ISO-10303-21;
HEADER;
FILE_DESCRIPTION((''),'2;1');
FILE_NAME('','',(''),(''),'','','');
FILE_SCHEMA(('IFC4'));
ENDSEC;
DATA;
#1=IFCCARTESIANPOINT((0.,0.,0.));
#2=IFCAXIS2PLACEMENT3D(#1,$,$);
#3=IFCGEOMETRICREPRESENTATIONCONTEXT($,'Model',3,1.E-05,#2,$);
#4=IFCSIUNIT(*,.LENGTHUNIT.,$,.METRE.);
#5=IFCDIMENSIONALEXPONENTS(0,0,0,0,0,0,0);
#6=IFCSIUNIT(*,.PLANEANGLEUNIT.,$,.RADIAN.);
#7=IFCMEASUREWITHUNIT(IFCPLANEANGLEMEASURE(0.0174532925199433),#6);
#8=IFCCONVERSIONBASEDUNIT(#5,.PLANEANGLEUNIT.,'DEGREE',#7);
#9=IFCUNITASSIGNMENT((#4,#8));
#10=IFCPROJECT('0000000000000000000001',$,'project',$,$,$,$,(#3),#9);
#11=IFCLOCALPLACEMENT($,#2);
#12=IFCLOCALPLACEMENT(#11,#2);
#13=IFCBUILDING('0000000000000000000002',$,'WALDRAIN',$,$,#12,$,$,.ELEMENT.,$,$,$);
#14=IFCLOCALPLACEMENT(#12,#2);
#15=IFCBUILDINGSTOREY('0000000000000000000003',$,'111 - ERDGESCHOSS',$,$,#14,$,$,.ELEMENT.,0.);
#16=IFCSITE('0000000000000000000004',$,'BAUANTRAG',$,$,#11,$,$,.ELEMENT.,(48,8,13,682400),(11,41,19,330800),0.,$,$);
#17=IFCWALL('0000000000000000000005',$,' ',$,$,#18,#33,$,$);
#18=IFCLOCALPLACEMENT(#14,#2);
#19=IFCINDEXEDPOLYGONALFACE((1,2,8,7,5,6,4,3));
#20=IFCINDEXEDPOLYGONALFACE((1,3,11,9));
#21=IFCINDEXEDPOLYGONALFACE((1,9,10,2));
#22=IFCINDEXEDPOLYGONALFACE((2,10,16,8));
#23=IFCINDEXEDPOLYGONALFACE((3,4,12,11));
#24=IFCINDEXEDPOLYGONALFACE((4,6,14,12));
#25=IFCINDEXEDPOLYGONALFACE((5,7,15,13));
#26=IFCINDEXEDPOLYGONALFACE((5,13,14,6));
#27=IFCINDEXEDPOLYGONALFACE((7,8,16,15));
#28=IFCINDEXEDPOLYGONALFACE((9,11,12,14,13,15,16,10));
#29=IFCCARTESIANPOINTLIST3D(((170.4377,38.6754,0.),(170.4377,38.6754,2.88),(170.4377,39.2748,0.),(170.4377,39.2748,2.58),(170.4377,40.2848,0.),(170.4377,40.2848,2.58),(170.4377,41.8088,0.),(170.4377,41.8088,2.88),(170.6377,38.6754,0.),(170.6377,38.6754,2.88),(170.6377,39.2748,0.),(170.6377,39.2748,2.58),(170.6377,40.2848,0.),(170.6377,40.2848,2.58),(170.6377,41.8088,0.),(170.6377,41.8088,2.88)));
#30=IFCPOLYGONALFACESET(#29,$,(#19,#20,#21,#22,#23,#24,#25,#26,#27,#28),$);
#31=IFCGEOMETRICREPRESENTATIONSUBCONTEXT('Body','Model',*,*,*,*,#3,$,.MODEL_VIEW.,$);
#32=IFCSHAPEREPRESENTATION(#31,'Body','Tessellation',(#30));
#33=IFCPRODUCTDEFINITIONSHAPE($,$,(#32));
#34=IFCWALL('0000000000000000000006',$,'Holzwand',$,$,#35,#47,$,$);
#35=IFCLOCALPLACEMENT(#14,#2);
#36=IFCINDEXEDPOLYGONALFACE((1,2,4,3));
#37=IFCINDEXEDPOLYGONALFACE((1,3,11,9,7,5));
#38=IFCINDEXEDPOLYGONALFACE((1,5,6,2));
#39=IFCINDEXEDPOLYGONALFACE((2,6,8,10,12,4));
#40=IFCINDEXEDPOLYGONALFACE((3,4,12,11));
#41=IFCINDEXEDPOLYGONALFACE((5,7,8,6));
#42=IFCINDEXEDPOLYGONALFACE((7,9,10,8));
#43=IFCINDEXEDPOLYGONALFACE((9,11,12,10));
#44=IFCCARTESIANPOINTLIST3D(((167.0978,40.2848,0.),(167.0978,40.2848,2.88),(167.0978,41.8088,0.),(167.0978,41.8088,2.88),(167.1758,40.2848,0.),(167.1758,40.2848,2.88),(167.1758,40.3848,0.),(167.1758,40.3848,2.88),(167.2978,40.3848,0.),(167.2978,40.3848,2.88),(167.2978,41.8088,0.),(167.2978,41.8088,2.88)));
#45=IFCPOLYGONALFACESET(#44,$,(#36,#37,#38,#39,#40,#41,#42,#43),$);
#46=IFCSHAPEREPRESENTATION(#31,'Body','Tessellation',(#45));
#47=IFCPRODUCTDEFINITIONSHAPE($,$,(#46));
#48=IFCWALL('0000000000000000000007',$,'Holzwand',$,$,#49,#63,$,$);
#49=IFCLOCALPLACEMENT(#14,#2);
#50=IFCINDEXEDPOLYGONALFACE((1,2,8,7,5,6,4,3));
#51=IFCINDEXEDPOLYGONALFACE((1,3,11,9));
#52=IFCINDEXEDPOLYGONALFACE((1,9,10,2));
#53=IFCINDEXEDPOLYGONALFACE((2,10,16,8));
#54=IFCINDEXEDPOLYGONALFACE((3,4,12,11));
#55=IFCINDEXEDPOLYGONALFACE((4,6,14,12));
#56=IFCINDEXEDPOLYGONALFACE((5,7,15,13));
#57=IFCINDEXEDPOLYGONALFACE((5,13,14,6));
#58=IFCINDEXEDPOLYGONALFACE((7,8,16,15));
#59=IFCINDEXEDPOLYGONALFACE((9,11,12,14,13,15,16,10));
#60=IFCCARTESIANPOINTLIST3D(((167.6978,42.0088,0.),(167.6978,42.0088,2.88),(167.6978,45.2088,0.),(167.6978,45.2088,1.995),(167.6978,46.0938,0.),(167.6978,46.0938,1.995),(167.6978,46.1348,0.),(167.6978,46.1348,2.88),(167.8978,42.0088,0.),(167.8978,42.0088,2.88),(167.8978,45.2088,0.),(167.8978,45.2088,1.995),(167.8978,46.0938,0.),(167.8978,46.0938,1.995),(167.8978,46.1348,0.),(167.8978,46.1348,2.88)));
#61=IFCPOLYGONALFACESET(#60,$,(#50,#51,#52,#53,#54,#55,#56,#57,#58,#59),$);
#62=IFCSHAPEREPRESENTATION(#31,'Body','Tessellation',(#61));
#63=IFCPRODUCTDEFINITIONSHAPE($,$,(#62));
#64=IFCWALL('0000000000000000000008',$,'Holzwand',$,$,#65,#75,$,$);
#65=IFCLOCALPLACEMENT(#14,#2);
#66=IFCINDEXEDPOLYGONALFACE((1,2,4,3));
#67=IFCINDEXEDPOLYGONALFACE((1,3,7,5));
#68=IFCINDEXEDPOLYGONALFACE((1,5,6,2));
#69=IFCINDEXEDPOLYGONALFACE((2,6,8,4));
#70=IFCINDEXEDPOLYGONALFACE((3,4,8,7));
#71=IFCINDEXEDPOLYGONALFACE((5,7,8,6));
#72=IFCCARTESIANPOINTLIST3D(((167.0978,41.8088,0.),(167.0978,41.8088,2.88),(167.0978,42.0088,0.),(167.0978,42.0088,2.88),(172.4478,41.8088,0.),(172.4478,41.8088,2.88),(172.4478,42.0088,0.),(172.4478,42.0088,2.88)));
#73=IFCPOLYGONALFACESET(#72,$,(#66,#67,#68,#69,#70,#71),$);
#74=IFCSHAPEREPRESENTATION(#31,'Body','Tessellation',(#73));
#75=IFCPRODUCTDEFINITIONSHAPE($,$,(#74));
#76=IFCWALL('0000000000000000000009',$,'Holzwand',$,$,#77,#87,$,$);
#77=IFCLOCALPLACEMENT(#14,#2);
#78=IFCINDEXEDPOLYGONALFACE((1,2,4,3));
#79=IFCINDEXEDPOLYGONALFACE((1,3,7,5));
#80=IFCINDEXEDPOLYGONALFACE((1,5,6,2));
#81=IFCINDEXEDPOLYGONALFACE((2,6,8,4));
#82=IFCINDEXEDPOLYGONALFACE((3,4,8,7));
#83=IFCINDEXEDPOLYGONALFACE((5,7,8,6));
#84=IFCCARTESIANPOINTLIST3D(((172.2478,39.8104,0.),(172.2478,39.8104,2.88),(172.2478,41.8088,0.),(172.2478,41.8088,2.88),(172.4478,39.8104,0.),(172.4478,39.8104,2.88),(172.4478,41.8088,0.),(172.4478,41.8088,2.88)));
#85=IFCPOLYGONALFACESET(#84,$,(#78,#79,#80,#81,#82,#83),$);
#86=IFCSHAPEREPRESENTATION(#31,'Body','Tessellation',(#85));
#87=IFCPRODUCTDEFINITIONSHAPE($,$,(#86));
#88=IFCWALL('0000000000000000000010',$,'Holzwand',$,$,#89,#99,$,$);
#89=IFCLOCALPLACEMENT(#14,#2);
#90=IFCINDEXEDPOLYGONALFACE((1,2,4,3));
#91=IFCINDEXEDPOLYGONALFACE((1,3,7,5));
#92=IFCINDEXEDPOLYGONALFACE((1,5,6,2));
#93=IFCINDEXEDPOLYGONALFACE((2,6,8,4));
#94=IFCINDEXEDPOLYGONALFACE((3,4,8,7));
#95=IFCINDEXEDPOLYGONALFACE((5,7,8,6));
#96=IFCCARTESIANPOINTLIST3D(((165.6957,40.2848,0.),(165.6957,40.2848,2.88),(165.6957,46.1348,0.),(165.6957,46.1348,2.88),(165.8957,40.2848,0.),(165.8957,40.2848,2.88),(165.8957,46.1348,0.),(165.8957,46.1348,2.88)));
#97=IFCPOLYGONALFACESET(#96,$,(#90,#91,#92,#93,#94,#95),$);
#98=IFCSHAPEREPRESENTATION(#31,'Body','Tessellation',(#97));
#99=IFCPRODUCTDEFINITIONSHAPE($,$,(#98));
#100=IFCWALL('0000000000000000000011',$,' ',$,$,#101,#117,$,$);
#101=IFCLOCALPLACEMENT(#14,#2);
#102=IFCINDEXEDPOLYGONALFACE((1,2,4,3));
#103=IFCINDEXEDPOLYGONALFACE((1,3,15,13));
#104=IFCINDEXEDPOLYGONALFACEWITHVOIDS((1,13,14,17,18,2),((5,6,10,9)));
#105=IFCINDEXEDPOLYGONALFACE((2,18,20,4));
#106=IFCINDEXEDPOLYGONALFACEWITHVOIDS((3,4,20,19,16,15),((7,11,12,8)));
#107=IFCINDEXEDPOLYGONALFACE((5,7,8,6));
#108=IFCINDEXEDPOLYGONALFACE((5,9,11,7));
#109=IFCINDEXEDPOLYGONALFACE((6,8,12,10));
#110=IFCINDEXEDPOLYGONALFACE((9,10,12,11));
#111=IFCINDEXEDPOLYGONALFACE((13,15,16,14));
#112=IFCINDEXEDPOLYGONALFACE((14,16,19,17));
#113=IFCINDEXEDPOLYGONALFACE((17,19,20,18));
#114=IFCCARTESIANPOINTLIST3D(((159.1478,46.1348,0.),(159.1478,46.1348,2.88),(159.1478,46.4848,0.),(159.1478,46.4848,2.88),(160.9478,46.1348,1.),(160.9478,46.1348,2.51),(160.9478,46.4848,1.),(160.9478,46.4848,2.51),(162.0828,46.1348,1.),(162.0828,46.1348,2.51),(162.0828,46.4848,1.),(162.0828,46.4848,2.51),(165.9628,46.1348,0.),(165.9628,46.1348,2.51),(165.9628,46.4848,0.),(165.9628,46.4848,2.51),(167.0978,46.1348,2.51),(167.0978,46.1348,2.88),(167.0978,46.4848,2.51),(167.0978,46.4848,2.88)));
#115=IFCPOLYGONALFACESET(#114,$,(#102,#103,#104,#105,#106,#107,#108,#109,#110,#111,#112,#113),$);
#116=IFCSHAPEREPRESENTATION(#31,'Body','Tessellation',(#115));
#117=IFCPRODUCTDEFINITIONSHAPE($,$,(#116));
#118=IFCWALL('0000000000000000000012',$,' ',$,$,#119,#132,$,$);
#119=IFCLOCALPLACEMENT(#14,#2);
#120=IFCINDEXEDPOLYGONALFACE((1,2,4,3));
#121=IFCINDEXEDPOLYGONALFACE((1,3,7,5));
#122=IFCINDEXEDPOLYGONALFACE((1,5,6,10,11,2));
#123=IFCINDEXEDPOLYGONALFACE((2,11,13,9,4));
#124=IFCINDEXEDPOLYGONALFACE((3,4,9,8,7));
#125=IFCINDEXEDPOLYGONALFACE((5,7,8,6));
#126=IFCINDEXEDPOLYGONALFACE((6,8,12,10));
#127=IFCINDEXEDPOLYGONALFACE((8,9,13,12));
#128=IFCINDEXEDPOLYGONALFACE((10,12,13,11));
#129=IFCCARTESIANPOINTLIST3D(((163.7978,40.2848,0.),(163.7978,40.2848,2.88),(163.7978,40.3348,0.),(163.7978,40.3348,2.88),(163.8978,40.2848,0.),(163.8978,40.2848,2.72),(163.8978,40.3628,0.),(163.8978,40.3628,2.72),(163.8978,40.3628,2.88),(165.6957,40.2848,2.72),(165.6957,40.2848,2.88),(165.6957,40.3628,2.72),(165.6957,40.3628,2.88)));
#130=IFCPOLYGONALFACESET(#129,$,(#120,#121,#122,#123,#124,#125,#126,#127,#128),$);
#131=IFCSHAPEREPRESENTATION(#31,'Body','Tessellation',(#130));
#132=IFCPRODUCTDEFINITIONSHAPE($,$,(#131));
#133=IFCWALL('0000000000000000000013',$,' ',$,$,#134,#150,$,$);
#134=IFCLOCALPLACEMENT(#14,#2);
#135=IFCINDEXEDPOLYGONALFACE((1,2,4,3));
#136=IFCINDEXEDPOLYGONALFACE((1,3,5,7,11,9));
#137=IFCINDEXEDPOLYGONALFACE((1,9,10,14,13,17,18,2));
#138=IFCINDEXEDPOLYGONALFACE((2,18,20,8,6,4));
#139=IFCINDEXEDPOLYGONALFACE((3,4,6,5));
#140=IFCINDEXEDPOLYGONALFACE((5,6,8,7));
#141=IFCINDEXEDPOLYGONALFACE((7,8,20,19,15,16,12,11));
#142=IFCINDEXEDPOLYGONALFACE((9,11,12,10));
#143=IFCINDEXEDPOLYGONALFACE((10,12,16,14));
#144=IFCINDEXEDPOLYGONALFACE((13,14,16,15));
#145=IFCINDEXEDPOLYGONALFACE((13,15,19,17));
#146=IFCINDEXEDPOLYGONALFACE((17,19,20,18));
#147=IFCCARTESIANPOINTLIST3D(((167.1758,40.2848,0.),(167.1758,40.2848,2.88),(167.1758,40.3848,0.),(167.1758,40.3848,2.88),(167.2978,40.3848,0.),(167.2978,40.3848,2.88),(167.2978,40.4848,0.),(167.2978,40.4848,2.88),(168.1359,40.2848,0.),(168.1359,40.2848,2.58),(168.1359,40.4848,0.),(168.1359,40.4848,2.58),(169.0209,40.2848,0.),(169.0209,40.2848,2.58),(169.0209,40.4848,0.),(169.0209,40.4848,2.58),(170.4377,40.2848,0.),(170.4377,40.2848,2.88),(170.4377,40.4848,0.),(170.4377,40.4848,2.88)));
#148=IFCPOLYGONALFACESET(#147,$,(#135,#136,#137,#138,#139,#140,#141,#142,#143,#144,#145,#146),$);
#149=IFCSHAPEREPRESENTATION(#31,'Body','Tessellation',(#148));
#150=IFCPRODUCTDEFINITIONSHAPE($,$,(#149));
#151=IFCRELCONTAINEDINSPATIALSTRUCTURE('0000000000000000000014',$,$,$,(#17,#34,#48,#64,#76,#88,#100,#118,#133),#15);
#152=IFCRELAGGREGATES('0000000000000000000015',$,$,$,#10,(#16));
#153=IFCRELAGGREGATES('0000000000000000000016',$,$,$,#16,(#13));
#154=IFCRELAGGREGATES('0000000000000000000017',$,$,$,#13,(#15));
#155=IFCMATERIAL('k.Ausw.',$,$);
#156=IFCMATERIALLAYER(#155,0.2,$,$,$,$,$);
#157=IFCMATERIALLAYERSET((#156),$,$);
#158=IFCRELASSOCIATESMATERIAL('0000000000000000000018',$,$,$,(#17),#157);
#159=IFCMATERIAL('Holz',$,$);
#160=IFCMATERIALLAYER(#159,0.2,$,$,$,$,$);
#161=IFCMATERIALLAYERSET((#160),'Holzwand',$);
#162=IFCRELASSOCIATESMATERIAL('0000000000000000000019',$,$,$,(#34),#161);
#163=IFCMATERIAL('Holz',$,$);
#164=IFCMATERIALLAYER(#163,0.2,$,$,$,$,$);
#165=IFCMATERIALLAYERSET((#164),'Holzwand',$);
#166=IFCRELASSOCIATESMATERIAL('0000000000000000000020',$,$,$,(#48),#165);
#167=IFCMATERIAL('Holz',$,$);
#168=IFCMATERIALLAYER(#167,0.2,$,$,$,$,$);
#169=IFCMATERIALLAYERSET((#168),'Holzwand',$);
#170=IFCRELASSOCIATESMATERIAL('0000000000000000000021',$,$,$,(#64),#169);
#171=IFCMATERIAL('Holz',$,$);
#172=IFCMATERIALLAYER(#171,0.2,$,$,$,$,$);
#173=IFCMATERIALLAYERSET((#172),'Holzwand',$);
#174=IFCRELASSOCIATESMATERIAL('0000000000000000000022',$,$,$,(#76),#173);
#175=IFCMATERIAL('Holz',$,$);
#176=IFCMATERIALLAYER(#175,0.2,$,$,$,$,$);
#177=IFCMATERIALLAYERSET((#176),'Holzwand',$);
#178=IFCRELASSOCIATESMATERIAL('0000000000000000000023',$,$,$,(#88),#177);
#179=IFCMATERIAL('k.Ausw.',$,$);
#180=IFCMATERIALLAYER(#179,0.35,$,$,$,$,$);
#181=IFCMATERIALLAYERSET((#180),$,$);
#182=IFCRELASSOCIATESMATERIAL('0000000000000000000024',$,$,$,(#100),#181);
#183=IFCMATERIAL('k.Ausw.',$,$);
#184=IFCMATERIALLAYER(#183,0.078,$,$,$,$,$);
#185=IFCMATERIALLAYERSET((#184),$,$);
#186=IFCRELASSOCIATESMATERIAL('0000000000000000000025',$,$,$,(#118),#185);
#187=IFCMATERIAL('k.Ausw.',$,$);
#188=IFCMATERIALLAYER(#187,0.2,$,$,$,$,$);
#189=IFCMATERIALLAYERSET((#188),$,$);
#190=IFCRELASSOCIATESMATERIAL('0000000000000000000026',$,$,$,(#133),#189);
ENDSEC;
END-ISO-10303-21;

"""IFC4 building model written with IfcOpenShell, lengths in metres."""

from ifc_helpers import new_model, entity, si_unit, converted_unit, frame, frame_2d, origin, origin_with_axes, place, context, subcontext, project, spatial, polyline, rectangle, outline, extrude, material, layer, layer_set, layer_usage, element, save


model = new_model("IFC4")

# Units and contexts
model_context = context("Model", 3, precision=1e-05, world=origin())
body_context = subcontext(model_context, "Body", "Model", "MODEL_VIEW")
ifc_project = project(units=[si_unit("LENGTHUNIT", "METRE"), converted_unit("PLANEANGLEUNIT", "DEGREE", entity("IfcPlaneAngleMeasure", 0.0174532925199433), si_unit("PLANEANGLEUNIT", "RADIAN"), dimensions=[0, 0, 0, 0, 0, 0, 0])], contexts=[model_context])

# Site, building, storey
site_placement = place(None, origin())
site = spatial("IfcSite", under=ifc_project, at=site_placement, Name="BAUANTRAG", CompositionType="ELEMENT", RefLatitude=(48, 8, 13, 682400), RefLongitude=(11, 41, 19, 330800), RefElevation=0.0)
building_placement = place(site_placement, origin())
building = spatial("IfcBuilding", under=site, at=building_placement, Name="WALDRAIN", CompositionType="ELEMENT")
storey_placement = place(building_placement, origin())
storey = spatial("IfcBuildingStorey", under=building, at=storey_placement, Name="111 - ERDGESCHOSS", CompositionType="ELEMENT", Elevation=0.0)

# Wall, opening
ifc_material_1 = material(Name="k.Ausw.")
ifc_layer_1 = layer(ifc_material_1, 0.2)
ifc_layer_set_1 = layer_set([ifc_layer_1])
ifc_layer_usage_1 = layer_usage(ifc_layer_set_1, "AXIS2", "POSITIVE", 0.0)
wall_1_placement = place(storey_placement, frame((170.4377, 41.8088, 0.0), z_axis=(0.0, 0.0, 1.0), x_axis=(0.0, -1.0, 0.0)))
wall_1 = element("IfcWall", 1, at=wall_1_placement, inside=storey, material=ifc_layer_usage_1, Name=" ", context=body_context, shape_type="SweptSolid", body=[
    extrude(rectangle(XDim=3.1334, YDim=0.2, at=frame_2d((1.5667, 0.1), x_axis=(1.0, 0.0))), origin_with_axes(), (0.0, 0.0, 1.0), 2.88),
])
opening_1_placement = place(wall_1_placement, frame((2.534, 0.2, -0.14), z_axis=(0.0, -1.0, 0.0), x_axis=(0.0, 0.0, 1.0)))
element("IfcOpeningElement", 2, at=opening_1_placement, cuts=wall_1, ObjectType="Opening", context=body_context, shape_type="SweptSolid", body=[
    extrude(outline(polyline([(0.0, 1.01), (2.72, 1.01), (2.72, 0.0), (0.0, 0.0), (0.0, 1.01)])), origin_with_axes(), (0.0, 0.0, 1.0), 0.2),
])

# Wall
ifc_material_2 = material(Name="Holz")
ifc_layer_2 = layer(ifc_material_2, 0.2)
ifc_layer_set_2 = layer_set([ifc_layer_2], Name="Holzwand")
ifc_layer_usage_2 = layer_usage(ifc_layer_set_2, "AXIS2", "POSITIVE", 0.0)
wall_2_placement = place(storey_placement, frame((167.0978, 41.8088, 0.0), z_axis=(0.0, 0.0, 1.0), x_axis=(0.0, -1.0, 0.0)))
element("IfcWall", 3, at=wall_2_placement, inside=storey, material=ifc_layer_usage_2, Name="Holzwand", context=body_context, shape_type="SweptSolid", body=[
    extrude(outline(polyline([(-1.524, 0.0), (0.0, 0.0), (0.0, 0.078), (-0.1, 0.078), (-0.1, 0.2), (-1.524, 0.2), (-1.524, 0.0)])), frame((1.524, 0.0, 0.0), z_axis=(0.0, 0.0, 1.0), x_axis=(1.0, 0.0, 0.0)), (0.0, 0.0, 1.0), 2.88),
])

# Wall, opening
ifc_material_3 = material(Name="Holz")
ifc_layer_3 = layer(ifc_material_3, 0.2)
ifc_layer_set_3 = layer_set([ifc_layer_3], Name="Holzwand")
ifc_layer_usage_3 = layer_usage(ifc_layer_set_3, "AXIS2", "POSITIVE", 0.0)
wall_3_placement = place(storey_placement, frame((167.6978, 46.1348, 0.0), z_axis=(0.0, 0.0, 1.0), x_axis=(0.0, -1.0, 0.0)))
wall_3 = element("IfcWall", 4, at=wall_3_placement, inside=storey, material=ifc_layer_usage_3, Name="Holzwand", context=body_context, shape_type="SweptSolid", body=[
    extrude(rectangle(XDim=4.126, YDim=0.2, at=frame_2d((2.063, 0.1), x_axis=(1.0, 0.0))), origin_with_axes(), (0.0, 0.0, 1.0), 2.88),
])
opening_2_placement = place(wall_3_placement, frame((0.926, 0.2, -0.14), z_axis=(0.0, -1.0, 0.0), x_axis=(0.0, 0.0, 1.0)))
element("IfcOpeningElement", 5, at=opening_2_placement, cuts=wall_3, ObjectType="Opening", context=body_context, shape_type="SweptSolid", body=[
    extrude(outline(polyline([(0.0, 0.885), (2.135, 0.885), (2.135, 0.0), (0.0, 0.0), (0.0, 0.885)])), origin_with_axes(), (0.0, 0.0, 1.0), 0.2),
])

# Walls
ifc_material_4 = material(Name="Holz")
ifc_layer_4 = layer(ifc_material_4, 0.2)
ifc_layer_set_4 = layer_set([ifc_layer_4], Name="Holzwand")
ifc_layer_usage_4 = layer_usage(ifc_layer_set_4, "AXIS2", "POSITIVE", 0.0)
wall_4_placement = place(storey_placement, frame((172.4478, 42.0088, 0.0), z_axis=(0.0, 0.0, 1.0), x_axis=(-1.0, 0.0, 0.0)))
element("IfcWall", 6, at=wall_4_placement, inside=storey, material=ifc_layer_usage_4, Name="Holzwand", context=body_context, shape_type="SweptSolid", body=[
    extrude(rectangle(XDim=5.35, YDim=0.2, at=frame_2d((2.675, 0.1), x_axis=(1.0, 0.0))), origin_with_axes(), (0.0, 0.0, 1.0), 2.88),
])
ifc_material_5 = material(Name="Holz")
ifc_layer_5 = layer(ifc_material_5, 0.2)
ifc_layer_set_5 = layer_set([ifc_layer_5], Name="Holzwand")
ifc_layer_usage_5 = layer_usage(ifc_layer_set_5, "AXIS2", "POSITIVE", 0.0)
wall_5_placement = place(storey_placement, frame((172.4478, 39.8104, 0.0), z_axis=(0.0, 0.0, 1.0), x_axis=(0.0, 1.0, 0.0)))
element("IfcWall", 7, at=wall_5_placement, inside=storey, material=ifc_layer_usage_5, Name="Holzwand", context=body_context, shape_type="SweptSolid", body=[
    extrude(rectangle(XDim=1.9984, YDim=0.2, at=frame_2d((0.9992, 0.1), x_axis=(1.0, 0.0))), origin_with_axes(), (0.0, 0.0, 1.0), 2.88),
])
ifc_material_6 = material(Name="Holz")
ifc_layer_6 = layer(ifc_material_6, 0.2)
ifc_layer_set_6 = layer_set([ifc_layer_6], Name="Holzwand")
ifc_layer_usage_6 = layer_usage(ifc_layer_set_6, "AXIS2", "POSITIVE", 0.0)
wall_6_placement = place(storey_placement, frame((165.6957, 46.1348, 0.0), z_axis=(0.0, 0.0, 1.0), x_axis=(0.0, -1.0, 0.0)))
element("IfcWall", 8, at=wall_6_placement, inside=storey, material=ifc_layer_usage_6, Name="Holzwand", context=body_context, shape_type="SweptSolid", body=[
    extrude(rectangle(XDim=5.85, YDim=0.2, at=frame_2d((2.925, 0.1), x_axis=(1.0, 0.0))), origin_with_axes(), (0.0, 0.0, 1.0), 2.88),
])

# Wall, openings
ifc_material_7 = material(Name="k.Ausw.")
ifc_layer_7 = layer(ifc_material_7, 0.35)
ifc_layer_set_7 = layer_set([ifc_layer_7])
ifc_layer_usage_7 = layer_usage(ifc_layer_set_7, "AXIS2", "POSITIVE", 0.0)
wall_7_placement = place(storey_placement, frame((167.0978, 46.4848, 0.0), z_axis=(0.0, 0.0, 1.0), x_axis=(-1.0, 0.0, 0.0)))
wall_7 = element("IfcWall", 9, at=wall_7_placement, inside=storey, material=ifc_layer_usage_7, Name=" ", context=body_context, shape_type="SweptSolid", body=[
    extrude(rectangle(XDim=7.95, YDim=0.35, at=frame_2d((3.975, 0.175), x_axis=(1.0, 0.0))), origin_with_axes(), (0.0, 0.0, 1.0), 2.88),
])
opening_3_placement = place(wall_7_placement, frame((6.15, 0.35, 1.0), z_axis=(0.0, -1.0, 0.0), x_axis=(0.0, 0.0, 1.0)))
element("IfcOpeningElement", 10, at=opening_3_placement, cuts=wall_7, ObjectType="Opening", context=body_context, shape_type="SweptSolid", body=[
    extrude(outline(polyline([(0.0, 1.135), (1.51, 1.135), (1.51, 0.0), (0.0, 0.0), (0.0, 1.135)])), origin_with_axes(), (0.0, 0.0, 1.0), 0.35),
])
opening_4_placement = place(wall_7_placement, frame((0.0, 0.0, -0.15), z_axis=(0.0, 1.0, 0.0), x_axis=(0.0, 0.0, 1.0)))
element("IfcOpeningElement", 11, at=opening_4_placement, cuts=wall_7, ObjectType="Opening", context=body_context, shape_type="SweptSolid", body=[
    extrude(outline(polyline([(0.0, 1.135), (2.66, 1.135), (2.66, 0.0), (0.0, 0.0), (0.0, 1.135)])), origin_with_axes(), (0.0, 0.0, 1.0), 0.35),
])

# Walls, openings
ifc_material_8 = material(Name="k.Ausw.")
ifc_layer_8 = layer(ifc_material_8, 0.078)
ifc_layer_set_8 = layer_set([ifc_layer_8])
ifc_layer_usage_8 = layer_usage(ifc_layer_set_8, "AXIS2", "POSITIVE", 0.0)
wall_8_placement = place(storey_placement, frame((165.6957, 40.3628, 0.0), z_axis=(0.0, 0.0, 1.0), x_axis=(-1.0, 0.0, 0.0)))
wall_8 = element("IfcWall", 12, at=wall_8_placement, inside=storey, material=ifc_layer_usage_8, Name=" ", context=body_context, shape_type="SweptSolid", body=[
    extrude(outline(polyline([(-1.8979, -0.078), (-0.1, -0.078), (0.0, -0.05), (0.0, 0.0), (-1.8979, 0.0), (-1.8979, -0.078)])), frame((1.8979, 0.078, 0.0), z_axis=(0.0, 0.0, 1.0), x_axis=(1.0, 0.0, 0.0)), (0.0, 0.0, 1.0), 2.88),
])
opening_5_placement = place(wall_8_placement, frame((1.7979, 0.078, 0.0), z_axis=(0.0, -1.0, 0.0), x_axis=(0.0, 0.0, 1.0)))
element("IfcOpeningElement", 13, at=opening_5_placement, cuts=wall_8, ObjectType="Opening", context=body_context, shape_type="SweptSolid", body=[
    extrude(outline(polyline([(0.0, 1.7979), (2.72, 1.7979), (2.72, 0.0), (0.0, 0.0), (0.0, 1.7979)])), origin_with_axes(), (0.0, 0.0, 1.0), 0.078),
])
ifc_material_9 = material(Name="k.Ausw.")
ifc_layer_9 = layer(ifc_material_9, 0.2)
ifc_layer_set_9 = layer_set([ifc_layer_9])
ifc_layer_usage_9 = layer_usage(ifc_layer_set_9, "AXIS2", "POSITIVE", 0.0)
wall_9_placement = place(storey_placement, frame((170.4377, 40.4848, 0.0), z_axis=(0.0, 0.0, 1.0), x_axis=(-1.0, 0.0, 0.0)))
wall_9 = element("IfcWall", 14, at=wall_9_placement, inside=storey, material=ifc_layer_usage_9, Name=" ", context=body_context, shape_type="SweptSolid", body=[
    extrude(outline(polyline([(-3.2619, -0.2), (-0.122, -0.2), (-0.122, -0.1), (0.0, -0.1), (0.0, 0.0), (-3.2619, 0.0), (-3.2619, -0.2)])), frame((3.2619, 0.2, 0.0), z_axis=(0.0, 0.0, 1.0), x_axis=(1.0, 0.0, 0.0)), (0.0, 0.0, 1.0), 2.88),
])
opening_6_placement = place(wall_9_placement, frame((2.3018, 0.2, -0.14), z_axis=(0.0, -1.0, 0.0), x_axis=(0.0, 0.0, 1.0)))
element("IfcOpeningElement", 15, at=opening_6_placement, cuts=wall_9, ObjectType="Opening", context=body_context, shape_type="SweptSolid", body=[
    extrude(outline(polyline([(0.0, 0.885), (2.72, 0.885), (2.72, 0.0), (0.0, 0.0), (0.0, 0.885)])), origin_with_axes(), (0.0, 0.0, 1.0), 0.2),
])

save(model, "model.ifc")
